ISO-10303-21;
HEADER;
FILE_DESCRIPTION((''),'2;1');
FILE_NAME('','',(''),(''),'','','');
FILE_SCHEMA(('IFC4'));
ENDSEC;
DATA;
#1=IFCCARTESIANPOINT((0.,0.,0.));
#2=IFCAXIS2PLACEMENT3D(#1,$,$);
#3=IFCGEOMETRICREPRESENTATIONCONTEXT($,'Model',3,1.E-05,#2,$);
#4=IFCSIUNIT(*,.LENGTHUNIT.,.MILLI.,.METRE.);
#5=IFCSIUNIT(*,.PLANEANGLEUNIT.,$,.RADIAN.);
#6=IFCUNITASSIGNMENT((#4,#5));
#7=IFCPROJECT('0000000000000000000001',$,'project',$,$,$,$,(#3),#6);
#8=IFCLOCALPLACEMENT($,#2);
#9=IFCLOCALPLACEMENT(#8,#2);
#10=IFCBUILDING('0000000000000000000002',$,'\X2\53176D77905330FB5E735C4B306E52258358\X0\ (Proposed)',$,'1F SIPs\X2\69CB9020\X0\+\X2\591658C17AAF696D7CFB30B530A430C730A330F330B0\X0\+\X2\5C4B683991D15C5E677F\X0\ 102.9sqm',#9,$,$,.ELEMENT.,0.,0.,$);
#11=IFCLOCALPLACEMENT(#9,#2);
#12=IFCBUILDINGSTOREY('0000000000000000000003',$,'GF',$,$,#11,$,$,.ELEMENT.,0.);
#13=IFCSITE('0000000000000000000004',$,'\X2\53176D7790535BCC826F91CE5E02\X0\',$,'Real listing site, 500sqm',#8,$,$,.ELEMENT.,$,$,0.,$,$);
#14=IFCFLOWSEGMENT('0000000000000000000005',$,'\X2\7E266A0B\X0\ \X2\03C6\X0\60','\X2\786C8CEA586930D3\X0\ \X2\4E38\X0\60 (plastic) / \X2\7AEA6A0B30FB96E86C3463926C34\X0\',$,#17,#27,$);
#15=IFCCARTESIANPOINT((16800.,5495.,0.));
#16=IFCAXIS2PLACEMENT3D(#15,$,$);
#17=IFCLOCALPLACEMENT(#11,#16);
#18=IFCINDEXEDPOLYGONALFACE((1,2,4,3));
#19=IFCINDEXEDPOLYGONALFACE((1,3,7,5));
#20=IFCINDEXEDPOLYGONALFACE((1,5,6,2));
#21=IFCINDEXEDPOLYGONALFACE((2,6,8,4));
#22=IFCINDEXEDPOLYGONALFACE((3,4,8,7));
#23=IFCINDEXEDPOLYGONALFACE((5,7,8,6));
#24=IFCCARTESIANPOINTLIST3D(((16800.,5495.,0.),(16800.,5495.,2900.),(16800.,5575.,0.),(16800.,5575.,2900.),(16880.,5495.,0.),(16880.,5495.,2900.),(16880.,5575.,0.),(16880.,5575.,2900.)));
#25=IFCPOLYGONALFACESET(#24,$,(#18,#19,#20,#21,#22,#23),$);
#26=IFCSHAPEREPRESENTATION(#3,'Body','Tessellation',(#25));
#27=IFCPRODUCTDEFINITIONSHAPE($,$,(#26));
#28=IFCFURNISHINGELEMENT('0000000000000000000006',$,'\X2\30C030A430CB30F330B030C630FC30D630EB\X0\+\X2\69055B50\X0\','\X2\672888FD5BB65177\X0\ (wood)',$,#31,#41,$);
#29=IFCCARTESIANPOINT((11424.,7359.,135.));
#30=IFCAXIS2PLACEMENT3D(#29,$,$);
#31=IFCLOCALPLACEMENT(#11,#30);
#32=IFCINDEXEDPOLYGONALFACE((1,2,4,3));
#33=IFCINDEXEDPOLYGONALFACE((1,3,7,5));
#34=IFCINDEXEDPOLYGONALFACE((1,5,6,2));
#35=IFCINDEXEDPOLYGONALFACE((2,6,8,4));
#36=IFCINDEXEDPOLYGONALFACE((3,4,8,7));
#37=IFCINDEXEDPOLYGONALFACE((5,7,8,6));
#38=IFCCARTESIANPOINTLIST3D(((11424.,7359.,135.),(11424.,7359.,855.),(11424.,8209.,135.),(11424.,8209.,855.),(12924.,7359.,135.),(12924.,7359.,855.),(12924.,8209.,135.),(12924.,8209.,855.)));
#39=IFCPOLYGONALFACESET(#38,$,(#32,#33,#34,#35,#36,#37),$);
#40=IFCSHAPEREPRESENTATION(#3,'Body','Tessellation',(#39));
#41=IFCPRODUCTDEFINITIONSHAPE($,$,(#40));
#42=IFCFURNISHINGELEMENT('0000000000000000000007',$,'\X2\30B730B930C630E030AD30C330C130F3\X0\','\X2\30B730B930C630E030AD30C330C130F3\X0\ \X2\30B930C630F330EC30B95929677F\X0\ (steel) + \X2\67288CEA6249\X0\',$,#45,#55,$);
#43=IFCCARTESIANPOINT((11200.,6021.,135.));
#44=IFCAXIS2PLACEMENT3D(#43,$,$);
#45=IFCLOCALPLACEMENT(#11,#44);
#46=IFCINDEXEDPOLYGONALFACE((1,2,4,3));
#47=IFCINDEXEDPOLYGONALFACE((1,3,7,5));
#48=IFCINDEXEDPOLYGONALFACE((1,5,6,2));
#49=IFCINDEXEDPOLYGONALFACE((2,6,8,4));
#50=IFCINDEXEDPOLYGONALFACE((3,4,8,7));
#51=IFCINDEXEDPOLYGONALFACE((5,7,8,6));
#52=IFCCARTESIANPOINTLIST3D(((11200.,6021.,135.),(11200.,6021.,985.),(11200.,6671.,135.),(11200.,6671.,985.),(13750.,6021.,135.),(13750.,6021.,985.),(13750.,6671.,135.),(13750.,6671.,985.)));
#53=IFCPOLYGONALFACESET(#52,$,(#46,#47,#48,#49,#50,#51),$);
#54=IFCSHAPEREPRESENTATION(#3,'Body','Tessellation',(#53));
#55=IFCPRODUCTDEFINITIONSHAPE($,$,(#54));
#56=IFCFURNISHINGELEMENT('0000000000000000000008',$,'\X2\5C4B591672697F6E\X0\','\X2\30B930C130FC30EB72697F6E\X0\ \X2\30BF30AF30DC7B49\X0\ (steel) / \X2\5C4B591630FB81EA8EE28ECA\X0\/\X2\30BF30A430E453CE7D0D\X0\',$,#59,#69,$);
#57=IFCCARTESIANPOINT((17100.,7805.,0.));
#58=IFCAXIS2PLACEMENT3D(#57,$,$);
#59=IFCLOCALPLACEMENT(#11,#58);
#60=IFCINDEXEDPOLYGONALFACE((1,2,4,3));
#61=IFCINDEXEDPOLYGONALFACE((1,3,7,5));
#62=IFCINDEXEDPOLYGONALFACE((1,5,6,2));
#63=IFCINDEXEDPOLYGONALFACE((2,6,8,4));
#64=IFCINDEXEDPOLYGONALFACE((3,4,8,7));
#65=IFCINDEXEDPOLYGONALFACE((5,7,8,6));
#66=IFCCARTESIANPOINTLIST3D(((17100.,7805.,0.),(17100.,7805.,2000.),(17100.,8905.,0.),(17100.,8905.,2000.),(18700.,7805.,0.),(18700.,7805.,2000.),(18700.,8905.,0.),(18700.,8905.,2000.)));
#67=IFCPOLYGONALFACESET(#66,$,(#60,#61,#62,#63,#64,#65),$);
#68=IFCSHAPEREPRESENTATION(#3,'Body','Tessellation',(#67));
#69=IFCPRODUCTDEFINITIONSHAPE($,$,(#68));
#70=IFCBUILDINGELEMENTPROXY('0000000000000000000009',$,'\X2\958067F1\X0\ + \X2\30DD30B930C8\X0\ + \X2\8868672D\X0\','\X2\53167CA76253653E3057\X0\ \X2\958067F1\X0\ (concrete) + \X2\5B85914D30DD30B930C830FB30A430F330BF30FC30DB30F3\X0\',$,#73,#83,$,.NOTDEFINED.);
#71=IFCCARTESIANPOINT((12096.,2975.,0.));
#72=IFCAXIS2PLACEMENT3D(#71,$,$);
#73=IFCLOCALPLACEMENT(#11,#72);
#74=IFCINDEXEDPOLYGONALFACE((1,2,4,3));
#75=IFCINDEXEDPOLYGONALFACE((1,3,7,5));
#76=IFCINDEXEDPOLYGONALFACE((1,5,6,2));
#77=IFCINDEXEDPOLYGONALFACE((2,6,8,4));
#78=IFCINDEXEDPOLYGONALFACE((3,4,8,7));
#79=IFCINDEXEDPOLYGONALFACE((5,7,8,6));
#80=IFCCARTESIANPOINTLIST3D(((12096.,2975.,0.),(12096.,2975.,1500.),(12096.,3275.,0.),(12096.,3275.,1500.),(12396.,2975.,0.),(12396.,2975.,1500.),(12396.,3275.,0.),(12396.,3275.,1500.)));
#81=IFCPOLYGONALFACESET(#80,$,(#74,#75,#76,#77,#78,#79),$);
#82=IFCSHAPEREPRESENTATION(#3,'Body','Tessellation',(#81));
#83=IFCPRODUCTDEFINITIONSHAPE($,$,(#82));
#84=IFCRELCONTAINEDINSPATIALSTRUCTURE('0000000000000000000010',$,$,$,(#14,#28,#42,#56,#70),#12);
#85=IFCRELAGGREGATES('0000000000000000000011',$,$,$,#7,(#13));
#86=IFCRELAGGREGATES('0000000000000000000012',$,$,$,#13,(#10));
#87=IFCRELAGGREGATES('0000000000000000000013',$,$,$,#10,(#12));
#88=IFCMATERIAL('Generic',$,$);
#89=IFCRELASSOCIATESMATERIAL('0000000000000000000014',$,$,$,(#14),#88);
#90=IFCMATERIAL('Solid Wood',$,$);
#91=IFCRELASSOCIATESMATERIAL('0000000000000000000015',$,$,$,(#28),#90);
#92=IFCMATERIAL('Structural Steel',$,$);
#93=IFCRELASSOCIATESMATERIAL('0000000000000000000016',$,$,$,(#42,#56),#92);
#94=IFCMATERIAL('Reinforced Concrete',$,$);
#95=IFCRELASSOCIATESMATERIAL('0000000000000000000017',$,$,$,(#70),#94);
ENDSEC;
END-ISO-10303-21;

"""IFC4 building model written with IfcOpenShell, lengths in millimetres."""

from ifc_helpers import new_model, si_unit, frame, frame_2d, origin, place, context, project, spatial, rectangle, extrude, material, element, save


model = new_model("IFC4")

# Units and contexts
model_context = context("Model", 3, precision=1e-05, world=origin())
ifc_project = project(units=[si_unit("LENGTHUNIT", "METRE", prefix="MILLI"), si_unit("PLANEANGLEUNIT", "RADIAN")], contexts=[model_context])

# Site, building, storey
site_placement = place(None, origin())
site = spatial("IfcSite", under=ifc_project, at=site_placement, Name="北海道富良野市", ObjectType="Real listing site, 500sqm", CompositionType="ELEMENT", RefElevation=0.0)
building_placement = place(site_placement, origin())
building = spatial("IfcBuilding", under=site, at=building_placement, Name="北海道・平屋の別荘 (Proposed)", ObjectType="1F SIPs構造+外壁窯業系サイディング+屋根金属板 102.9sqm", CompositionType="ELEMENT", ElevationOfRefHeight=0.0, ElevationOfTerrain=0.0)
storey_placement = place(building_placement, origin())
storey = spatial("IfcBuildingStorey", under=building, at=storey_placement, Name="GF", CompositionType="ELEMENT", Elevation=0.0)

# Shared definitions
ifc_material_1 = material(Name="Solid Wood")

# Shared definitions
ifc_material_2 = material(Name="Reinforced Concrete")

# Shared definitions
ifc_material_3 = material(Name="Structural Steel")

# Shared definitions
ifc_material_4 = material(Name="Generic")

# Flow segment
flow_segment_placement = place(storey_placement, frame((16800.0, 5495.0, 0.0)))
element("IfcFlowSegment", 1, at=flow_segment_placement, inside=storey, material=ifc_material_4, Name="縦樋 φ60", Description="硬質塩ビ 丸60 (plastic) / 竪樋・雨水排水", context=model_context, shape_type="SweptSolid", body=[
    extrude(rectangle(XDim=80.0, YDim=80.0, at=frame_2d((40.0, 40.0))), frame((16800.0, 5495.0, 0.0)), (0.0, 0.0, 1.0), 2900.0),
])

# Furnishing elements
furnishing_1_placement = place(storey_placement, frame((11424.0, 7359.0, 135.0)))
element("IfcFurnishingElement", 2, at=furnishing_1_placement, inside=storey, material=ifc_material_1, Name="ダイニングテーブル+椅子", Description="木製家具 (wood)", context=model_context, shape_type="SweptSolid", body=[
    extrude(rectangle(XDim=1500.0, YDim=850.0, at=frame_2d((750.0, 425.0))), frame((11424.0, 7359.0, 135.0)), (0.0, 0.0, 1.0), 720.0),
])
furnishing_2_placement = place(storey_placement, frame((11200.0, 6021.0, 135.0)))
element("IfcFurnishingElement", 3, at=furnishing_2_placement, inside=storey, material=ifc_material_3, Name="システムキッチン", Description="システムキッチン ステンレス天板 (steel) + 木質扉", context=model_context, shape_type="SweptSolid", body=[
    extrude(rectangle(XDim=2550.0, YDim=650.0, at=frame_2d((1275.0, 325.0))), frame((11200.0, 6021.0, 135.0)), (0.0, 0.0, 1.0), 850.0),
])
furnishing_3_placement = place(storey_placement, frame((17100.0, 7805.0, 0.0)))
element("IfcFurnishingElement", 4, at=furnishing_3_placement, inside=storey, material=ifc_material_3, Name="屋外物置", Description="スチール物置 タクボ等 (steel) / 屋外・自転車/タイヤ収納", context=model_context, shape_type="SweptSolid", body=[
    extrude(rectangle(XDim=1600.0, YDim=1100.0, at=frame_2d((800.0, 550.0))), frame((17100.0, 7805.0, 0.0)), (0.0, 0.0, 1.0), 2000.0),
])

# Building element proxy
proxy_placement = place(storey_placement, frame((12096.0, 2975.0, 0.0)))
element("IfcBuildingElementProxy", 5, at=proxy_placement, inside=storey, material=ifc_material_2, Name="門柱 + ポスト + 表札", Description="化粧打放し 門柱 (concrete) + 宅配ポスト・インターホン", PredefinedType="NOTDEFINED", context=model_context, shape_type="SweptSolid", body=[
    extrude(rectangle(XDim=300.0, YDim=300.0, at=frame_2d((150.0, 150.0))), frame((12096.0, 2975.0, 0.0)), (0.0, 0.0, 1.0), 1500.0),
])

save(model, "model.ifc")
